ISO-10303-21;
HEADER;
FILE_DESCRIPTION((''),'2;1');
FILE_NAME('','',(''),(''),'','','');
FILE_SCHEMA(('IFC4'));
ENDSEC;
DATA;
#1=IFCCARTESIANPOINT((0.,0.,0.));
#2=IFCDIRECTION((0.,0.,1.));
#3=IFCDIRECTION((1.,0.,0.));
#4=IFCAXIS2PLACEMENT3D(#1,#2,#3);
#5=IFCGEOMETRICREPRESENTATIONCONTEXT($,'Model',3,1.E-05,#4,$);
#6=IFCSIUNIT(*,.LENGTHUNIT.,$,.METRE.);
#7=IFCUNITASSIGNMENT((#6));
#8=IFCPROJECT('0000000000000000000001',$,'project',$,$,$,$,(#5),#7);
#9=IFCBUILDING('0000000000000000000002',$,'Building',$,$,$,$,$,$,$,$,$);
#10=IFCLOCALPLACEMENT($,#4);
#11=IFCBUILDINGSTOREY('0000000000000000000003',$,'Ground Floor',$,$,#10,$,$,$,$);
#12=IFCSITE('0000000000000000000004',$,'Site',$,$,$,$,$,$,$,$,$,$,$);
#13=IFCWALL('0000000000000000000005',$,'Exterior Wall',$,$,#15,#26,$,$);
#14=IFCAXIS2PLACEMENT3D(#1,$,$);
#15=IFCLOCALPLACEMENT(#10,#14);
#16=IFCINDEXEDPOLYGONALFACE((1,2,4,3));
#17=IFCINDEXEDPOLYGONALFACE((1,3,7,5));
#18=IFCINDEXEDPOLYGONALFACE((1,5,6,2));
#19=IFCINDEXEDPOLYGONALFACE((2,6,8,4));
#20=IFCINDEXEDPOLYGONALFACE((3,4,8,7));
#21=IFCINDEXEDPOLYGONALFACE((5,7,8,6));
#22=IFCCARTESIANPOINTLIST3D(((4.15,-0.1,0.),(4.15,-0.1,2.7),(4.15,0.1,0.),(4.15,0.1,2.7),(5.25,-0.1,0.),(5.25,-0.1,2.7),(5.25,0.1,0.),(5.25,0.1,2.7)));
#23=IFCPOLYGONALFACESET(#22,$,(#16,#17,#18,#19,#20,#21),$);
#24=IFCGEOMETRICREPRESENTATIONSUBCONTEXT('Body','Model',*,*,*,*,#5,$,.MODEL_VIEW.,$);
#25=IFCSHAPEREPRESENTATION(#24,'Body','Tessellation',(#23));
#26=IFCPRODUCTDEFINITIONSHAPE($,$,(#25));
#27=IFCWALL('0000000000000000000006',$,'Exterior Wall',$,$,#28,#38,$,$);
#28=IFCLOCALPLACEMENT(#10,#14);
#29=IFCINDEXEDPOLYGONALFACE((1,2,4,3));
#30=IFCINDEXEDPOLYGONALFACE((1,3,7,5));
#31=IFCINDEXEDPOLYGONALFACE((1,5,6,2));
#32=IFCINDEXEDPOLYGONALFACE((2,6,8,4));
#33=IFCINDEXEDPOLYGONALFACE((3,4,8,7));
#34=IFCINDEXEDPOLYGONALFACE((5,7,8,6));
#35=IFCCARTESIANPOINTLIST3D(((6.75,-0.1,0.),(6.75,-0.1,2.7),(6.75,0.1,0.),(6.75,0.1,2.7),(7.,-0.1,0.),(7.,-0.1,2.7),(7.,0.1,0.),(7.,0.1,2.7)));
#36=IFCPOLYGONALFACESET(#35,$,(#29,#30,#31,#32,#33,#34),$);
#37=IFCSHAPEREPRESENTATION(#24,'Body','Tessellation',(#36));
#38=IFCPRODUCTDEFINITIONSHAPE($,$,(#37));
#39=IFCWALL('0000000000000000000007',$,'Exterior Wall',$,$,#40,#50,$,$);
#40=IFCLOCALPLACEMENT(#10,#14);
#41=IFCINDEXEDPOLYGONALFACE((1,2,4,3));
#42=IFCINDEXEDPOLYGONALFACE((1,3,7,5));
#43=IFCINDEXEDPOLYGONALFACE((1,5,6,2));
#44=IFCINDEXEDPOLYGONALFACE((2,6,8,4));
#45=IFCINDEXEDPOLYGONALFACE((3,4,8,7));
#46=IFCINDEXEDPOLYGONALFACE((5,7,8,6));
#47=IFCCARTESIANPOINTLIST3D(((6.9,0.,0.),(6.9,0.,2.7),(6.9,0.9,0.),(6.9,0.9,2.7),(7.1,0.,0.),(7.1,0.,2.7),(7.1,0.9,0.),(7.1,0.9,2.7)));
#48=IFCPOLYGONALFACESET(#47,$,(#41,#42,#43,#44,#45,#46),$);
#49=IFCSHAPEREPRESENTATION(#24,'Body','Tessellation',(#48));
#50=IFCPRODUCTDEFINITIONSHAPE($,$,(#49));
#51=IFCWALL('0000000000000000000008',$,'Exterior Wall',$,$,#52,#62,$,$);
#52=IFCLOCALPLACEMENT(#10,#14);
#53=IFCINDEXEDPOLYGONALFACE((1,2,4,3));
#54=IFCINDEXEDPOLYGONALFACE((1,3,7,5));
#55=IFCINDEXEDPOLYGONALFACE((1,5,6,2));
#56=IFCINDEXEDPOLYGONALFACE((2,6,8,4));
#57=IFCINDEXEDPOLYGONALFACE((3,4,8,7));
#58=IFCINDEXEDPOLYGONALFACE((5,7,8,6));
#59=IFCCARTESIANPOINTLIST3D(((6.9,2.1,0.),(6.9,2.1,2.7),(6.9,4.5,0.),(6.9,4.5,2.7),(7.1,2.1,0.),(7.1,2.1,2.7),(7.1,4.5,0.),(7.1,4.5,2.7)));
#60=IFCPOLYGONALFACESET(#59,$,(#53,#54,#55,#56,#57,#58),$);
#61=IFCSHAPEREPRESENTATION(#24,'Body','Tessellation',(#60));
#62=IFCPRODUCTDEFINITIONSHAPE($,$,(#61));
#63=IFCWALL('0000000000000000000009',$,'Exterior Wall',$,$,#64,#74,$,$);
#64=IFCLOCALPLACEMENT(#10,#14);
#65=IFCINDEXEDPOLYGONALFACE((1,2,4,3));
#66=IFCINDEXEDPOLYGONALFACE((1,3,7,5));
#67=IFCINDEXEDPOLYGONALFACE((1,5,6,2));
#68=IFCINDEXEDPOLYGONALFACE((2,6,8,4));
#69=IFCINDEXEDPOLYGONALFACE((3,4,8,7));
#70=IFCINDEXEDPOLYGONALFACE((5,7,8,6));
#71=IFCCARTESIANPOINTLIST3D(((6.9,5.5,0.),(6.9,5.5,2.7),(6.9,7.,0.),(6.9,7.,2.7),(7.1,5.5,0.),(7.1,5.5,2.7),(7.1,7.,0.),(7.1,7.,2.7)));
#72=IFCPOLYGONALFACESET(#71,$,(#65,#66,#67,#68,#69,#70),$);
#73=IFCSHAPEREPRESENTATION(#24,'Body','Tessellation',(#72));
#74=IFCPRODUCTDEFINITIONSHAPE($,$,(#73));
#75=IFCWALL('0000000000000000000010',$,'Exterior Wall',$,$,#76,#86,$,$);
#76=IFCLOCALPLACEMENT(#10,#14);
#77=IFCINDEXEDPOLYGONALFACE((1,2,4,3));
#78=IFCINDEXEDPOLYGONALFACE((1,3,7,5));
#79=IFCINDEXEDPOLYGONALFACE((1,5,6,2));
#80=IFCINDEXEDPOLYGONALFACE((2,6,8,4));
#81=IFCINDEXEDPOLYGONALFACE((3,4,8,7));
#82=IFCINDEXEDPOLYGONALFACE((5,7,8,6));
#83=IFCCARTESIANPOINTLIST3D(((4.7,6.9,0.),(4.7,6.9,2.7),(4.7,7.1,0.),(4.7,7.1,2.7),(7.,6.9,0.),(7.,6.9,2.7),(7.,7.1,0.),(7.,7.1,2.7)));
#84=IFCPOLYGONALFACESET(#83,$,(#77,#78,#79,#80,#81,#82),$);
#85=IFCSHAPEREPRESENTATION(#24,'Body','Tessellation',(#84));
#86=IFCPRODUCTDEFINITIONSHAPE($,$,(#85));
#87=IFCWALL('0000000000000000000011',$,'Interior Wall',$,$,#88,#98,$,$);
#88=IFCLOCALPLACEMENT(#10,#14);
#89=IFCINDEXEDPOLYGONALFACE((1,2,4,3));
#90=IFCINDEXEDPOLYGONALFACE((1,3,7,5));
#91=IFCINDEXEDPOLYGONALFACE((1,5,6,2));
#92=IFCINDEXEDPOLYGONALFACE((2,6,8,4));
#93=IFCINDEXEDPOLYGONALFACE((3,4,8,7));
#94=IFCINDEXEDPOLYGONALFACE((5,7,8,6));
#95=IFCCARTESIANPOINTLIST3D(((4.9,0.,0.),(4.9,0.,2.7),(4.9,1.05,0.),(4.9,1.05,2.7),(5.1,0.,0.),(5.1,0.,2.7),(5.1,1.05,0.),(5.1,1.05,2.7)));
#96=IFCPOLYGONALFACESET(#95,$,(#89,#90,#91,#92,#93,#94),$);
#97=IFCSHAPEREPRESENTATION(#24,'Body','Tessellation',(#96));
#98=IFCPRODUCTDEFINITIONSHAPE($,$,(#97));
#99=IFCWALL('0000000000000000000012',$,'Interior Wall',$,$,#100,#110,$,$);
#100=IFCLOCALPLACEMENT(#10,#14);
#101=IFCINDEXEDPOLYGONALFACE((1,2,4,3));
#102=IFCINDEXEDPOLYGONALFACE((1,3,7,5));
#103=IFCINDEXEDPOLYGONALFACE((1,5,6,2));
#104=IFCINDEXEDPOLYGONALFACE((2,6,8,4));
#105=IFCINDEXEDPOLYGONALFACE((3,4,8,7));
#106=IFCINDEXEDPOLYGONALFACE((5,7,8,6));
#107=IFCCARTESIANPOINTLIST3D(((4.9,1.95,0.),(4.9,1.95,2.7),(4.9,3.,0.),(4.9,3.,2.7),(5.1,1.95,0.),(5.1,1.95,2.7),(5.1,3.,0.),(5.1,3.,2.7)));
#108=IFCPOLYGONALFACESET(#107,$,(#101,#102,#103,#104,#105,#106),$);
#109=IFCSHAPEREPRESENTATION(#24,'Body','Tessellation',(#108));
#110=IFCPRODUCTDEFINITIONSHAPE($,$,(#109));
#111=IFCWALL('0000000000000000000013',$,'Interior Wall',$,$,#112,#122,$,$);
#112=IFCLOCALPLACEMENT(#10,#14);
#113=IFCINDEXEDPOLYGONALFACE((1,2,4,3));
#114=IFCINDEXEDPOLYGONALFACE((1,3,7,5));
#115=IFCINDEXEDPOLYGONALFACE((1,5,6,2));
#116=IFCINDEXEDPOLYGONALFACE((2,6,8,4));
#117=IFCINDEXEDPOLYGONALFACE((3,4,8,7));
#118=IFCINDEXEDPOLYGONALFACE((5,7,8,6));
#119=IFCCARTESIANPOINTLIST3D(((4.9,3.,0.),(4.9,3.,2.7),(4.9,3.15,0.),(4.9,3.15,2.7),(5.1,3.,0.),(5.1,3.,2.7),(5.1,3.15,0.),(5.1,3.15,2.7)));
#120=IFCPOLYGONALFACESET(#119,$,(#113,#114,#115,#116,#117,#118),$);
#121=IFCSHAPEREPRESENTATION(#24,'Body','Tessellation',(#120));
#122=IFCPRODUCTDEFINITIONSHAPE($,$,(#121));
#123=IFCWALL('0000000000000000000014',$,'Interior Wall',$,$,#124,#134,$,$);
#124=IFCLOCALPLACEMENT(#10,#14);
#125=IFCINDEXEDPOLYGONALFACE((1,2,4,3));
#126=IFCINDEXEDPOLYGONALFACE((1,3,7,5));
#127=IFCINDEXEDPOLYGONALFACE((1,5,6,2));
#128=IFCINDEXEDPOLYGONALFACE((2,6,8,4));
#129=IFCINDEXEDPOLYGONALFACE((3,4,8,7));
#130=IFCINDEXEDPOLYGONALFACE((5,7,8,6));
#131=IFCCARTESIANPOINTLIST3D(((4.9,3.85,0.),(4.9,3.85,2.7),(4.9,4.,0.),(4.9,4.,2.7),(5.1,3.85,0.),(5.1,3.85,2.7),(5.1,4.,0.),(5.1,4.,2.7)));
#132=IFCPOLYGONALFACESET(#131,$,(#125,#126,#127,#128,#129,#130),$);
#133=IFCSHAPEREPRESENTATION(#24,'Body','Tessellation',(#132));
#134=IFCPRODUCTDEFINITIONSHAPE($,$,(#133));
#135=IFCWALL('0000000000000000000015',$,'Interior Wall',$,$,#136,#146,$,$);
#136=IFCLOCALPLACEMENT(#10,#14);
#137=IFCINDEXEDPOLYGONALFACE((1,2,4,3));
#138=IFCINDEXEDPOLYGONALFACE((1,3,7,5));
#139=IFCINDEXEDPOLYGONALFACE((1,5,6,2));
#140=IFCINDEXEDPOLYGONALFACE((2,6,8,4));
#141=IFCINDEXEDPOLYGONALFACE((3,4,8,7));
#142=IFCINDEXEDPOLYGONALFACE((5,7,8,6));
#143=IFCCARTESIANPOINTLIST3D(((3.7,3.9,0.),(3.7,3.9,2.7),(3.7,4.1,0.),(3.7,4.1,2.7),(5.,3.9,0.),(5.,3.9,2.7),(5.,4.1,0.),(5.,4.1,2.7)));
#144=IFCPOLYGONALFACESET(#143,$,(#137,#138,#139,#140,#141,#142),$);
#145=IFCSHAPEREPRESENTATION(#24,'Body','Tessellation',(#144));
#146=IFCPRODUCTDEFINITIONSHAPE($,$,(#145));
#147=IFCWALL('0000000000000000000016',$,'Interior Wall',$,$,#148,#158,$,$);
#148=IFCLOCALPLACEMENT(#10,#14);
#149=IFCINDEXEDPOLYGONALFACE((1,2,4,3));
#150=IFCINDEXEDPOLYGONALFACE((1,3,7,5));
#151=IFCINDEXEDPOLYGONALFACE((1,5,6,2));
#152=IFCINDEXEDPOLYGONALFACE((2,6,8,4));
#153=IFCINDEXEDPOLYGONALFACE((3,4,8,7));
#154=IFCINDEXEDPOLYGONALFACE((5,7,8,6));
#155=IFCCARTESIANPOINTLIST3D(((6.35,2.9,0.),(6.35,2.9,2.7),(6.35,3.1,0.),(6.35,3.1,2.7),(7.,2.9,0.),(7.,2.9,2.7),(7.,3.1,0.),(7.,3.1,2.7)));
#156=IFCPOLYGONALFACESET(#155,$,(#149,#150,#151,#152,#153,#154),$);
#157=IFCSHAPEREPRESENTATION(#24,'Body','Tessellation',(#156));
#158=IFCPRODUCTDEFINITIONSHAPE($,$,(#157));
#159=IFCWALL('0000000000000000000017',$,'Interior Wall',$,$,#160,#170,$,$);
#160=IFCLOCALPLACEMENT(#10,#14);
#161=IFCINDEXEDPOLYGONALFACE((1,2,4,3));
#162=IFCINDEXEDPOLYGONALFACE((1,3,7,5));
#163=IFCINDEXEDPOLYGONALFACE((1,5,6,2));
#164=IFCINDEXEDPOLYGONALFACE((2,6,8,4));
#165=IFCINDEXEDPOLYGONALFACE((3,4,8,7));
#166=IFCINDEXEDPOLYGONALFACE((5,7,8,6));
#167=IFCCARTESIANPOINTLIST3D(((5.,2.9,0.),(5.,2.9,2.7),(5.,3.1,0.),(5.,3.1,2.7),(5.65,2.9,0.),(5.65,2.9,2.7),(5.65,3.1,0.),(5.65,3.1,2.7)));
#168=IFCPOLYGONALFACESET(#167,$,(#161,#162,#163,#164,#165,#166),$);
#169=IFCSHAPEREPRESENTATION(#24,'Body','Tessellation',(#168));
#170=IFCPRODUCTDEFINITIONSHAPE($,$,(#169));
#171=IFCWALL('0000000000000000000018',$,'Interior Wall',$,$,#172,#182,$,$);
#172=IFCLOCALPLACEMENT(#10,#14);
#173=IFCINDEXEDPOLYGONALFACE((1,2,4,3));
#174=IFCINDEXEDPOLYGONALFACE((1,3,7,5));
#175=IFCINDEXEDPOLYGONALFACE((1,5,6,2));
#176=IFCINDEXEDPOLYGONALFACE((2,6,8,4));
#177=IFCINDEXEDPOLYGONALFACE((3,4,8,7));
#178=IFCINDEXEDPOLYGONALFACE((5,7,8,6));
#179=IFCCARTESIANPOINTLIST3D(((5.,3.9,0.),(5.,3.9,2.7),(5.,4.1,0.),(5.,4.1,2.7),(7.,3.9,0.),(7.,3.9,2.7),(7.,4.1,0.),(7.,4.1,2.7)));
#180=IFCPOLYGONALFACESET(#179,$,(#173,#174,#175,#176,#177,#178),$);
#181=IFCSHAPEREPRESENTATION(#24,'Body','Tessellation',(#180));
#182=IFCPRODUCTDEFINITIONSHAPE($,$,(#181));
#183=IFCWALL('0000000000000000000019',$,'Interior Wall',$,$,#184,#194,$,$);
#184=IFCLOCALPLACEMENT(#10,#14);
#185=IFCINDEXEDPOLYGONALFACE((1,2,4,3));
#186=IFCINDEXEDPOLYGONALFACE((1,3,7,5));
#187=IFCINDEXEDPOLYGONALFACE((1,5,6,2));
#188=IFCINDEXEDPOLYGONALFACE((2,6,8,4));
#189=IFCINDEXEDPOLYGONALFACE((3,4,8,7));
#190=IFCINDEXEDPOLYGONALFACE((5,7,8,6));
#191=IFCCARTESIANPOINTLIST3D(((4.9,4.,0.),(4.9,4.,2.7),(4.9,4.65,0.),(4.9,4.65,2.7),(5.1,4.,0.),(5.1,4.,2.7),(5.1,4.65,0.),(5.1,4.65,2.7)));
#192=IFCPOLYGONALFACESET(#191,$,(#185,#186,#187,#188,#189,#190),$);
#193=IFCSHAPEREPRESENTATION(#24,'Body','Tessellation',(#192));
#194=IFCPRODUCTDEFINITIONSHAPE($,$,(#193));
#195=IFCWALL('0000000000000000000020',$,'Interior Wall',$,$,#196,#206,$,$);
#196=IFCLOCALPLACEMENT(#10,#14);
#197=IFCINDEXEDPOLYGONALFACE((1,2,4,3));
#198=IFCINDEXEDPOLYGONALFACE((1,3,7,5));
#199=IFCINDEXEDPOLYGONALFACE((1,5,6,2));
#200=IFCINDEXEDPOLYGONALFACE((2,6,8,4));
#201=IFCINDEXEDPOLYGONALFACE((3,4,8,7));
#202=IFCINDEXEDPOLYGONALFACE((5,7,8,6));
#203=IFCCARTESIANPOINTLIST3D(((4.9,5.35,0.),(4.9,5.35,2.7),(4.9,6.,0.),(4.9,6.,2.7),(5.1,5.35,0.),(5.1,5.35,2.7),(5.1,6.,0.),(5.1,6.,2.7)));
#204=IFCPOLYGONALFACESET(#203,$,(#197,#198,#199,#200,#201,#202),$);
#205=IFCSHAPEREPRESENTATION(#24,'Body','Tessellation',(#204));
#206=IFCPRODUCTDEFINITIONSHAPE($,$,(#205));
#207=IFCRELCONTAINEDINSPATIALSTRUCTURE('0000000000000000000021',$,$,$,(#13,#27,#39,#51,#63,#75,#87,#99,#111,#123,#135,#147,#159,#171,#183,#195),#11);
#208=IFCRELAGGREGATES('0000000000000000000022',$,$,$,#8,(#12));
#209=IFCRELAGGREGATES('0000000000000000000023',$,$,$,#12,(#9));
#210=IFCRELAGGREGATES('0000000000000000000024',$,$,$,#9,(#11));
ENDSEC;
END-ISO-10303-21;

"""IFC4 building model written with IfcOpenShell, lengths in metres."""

from ifc_helpers import new_model, si_unit, frame, origin_with_axes, place, context, subcontext, project, spatial, indexed_curve, outline, extrude, element, save


model = new_model("IFC4")

# Units and contexts
model_context = context("Model", 3, precision=1e-05, world=origin_with_axes())
body_context = subcontext(model_context, "Body", "Model", "MODEL_VIEW")
ifc_project = project(units=[si_unit("LENGTHUNIT", "METRE")], contexts=[model_context])

# Site, building, storey
site = spatial("IfcSite", under=ifc_project, Name="Site")
building = spatial("IfcBuilding", under=site, Name="Building")
storey_placement = place(None, origin_with_axes())
storey = spatial("IfcBuildingStorey", under=building, at=storey_placement, Name="Ground Floor")

# Walls
wall_1_placement = place(storey_placement, frame((4.15, 0.0, 0.0), z_axis=(0.0, 0.0, 1.0), x_axis=(1.0, 0.0, 0.0)))
element("IfcWall", 1, at=wall_1_placement, inside=storey, Name="Exterior Wall", context=body_context, shape_type="SweptSolid", body=[
    extrude(outline(indexed_curve([(0.0, 0.0), (0.0, 0.2), (1.1, 0.2), (1.1, 0.0), (0.0, 0.0)], self_intersect=False)), frame((0.0, -0.1, 0.0), z_axis=(0.0, 0.0, 1.0), x_axis=(1.0, 0.0, 0.0)), (0.0, 0.0, 1.0), 2.7),
])
wall_2_placement = place(storey_placement, frame((6.75, 0.0, 0.0), z_axis=(0.0, 0.0, 1.0), x_axis=(1.0, 0.0, 0.0)))
element("IfcWall", 2, at=wall_2_placement, inside=storey, Name="Exterior Wall", context=body_context, shape_type="SweptSolid", body=[
    extrude(outline(indexed_curve([(0.0, 0.0), (0.0, 0.2), (0.25, 0.2), (0.25, 0.0), (0.0, 0.0)], self_intersect=False)), frame((0.0, -0.1, 0.0), z_axis=(0.0, 0.0, 1.0), x_axis=(1.0, 0.0, 0.0)), (0.0, 0.0, 1.0), 2.7),
])
wall_3_placement = place(storey_placement, frame((7.0, 0.0, 0.0), z_axis=(0.0, 0.0, 1.0), x_axis=(0.0, 1.0, 0.0)))
element("IfcWall", 3, at=wall_3_placement, inside=storey, Name="Exterior Wall", context=body_context, shape_type="SweptSolid", body=[
    extrude(outline(indexed_curve([(0.0, 0.0), (0.0, 0.2), (0.9, 0.2), (0.9, 0.0), (0.0, 0.0)], self_intersect=False)), frame((0.0, -0.1, 0.0), z_axis=(0.0, 0.0, 1.0), x_axis=(1.0, 0.0, 0.0)), (0.0, 0.0, 1.0), 2.7),
])
wall_4_placement = place(storey_placement, frame((7.0, 2.1, 0.0), z_axis=(0.0, 0.0, 1.0), x_axis=(0.0, 1.0, 0.0)))
element("IfcWall", 4, at=wall_4_placement, inside=storey, Name="Exterior Wall", context=body_context, shape_type="SweptSolid", body=[
    extrude(outline(indexed_curve([(0.0, 0.0), (0.0, 0.2), (2.4, 0.2), (2.4, 0.0), (0.0, 0.0)], self_intersect=False)), frame((0.0, -0.1, 0.0), z_axis=(0.0, 0.0, 1.0), x_axis=(1.0, 0.0, 0.0)), (0.0, 0.0, 1.0), 2.7),
])
wall_5_placement = place(storey_placement, frame((7.0, 5.5, 0.0), z_axis=(0.0, 0.0, 1.0), x_axis=(0.0, 1.0, 0.0)))
element("IfcWall", 5, at=wall_5_placement, inside=storey, Name="Exterior Wall", context=body_context, shape_type="SweptSolid", body=[
    extrude(outline(indexed_curve([(0.0, 0.0), (0.0, 0.2), (1.5, 0.2), (1.5, 0.0), (0.0, 0.0)], self_intersect=False)), frame((0.0, -0.1, 0.0), z_axis=(0.0, 0.0, 1.0), x_axis=(1.0, 0.0, 0.0)), (0.0, 0.0, 1.0), 2.7),
])
wall_6_placement = place(storey_placement, frame((7.0, 7.0, 0.0), z_axis=(0.0, 0.0, 1.0), x_axis=(-1.0, 0.0, 0.0)))
element("IfcWall", 6, at=wall_6_placement, inside=storey, Name="Exterior Wall", context=body_context, shape_type="SweptSolid", body=[
    extrude(outline(indexed_curve([(0.0, 0.0), (0.0, 0.2), (2.3, 0.2), (2.3, 0.0), (0.0, 0.0)], self_intersect=False)), frame((0.0, -0.1, 0.0), z_axis=(0.0, 0.0, 1.0), x_axis=(1.0, 0.0, 0.0)), (0.0, 0.0, 1.0), 2.7),
])
for number, where, z_axis, x_axis, name in (
    (7, (5.0, 0.0, 0.0), (0.0, 0.0, 1.0), (0.0, 1.0, 0.0), "Interior Wall"),
    (8, (5.0, 1.95, 0.0), (0.0, 0.0, 1.0), (0.0, 1.0, 0.0), "Interior Wall"),
):
    element("IfcWall", number, at=place(storey_placement, frame(where, z_axis=z_axis, x_axis=x_axis)), inside=storey, Name=name, context=body_context, shape_type="SweptSolid", body=[
        extrude(outline(indexed_curve([(0.0, 0.0), (0.0, 0.2), (1.05, 0.2), (1.05, 0.0), (0.0, 0.0)], self_intersect=False)), frame((0.0, -0.1, 0.0), z_axis=(0.0, 0.0, 1.0), x_axis=(1.0, 0.0, 0.0)), (0.0, 0.0, 1.0), 2.7),
    ])
for number, where, z_axis, x_axis, name in (
    (9, (5.0, 3.0, 0.0), (0.0, 0.0, 1.0), (0.0, 1.0, 0.0), "Interior Wall"),
    (10, (5.0, 3.85, 0.0), (0.0, 0.0, 1.0), (0.0, 1.0, 0.0), "Interior Wall"),
):
    element("IfcWall", number, at=place(storey_placement, frame(where, z_axis=z_axis, x_axis=x_axis)), inside=storey, Name=name, context=body_context, shape_type="SweptSolid", body=[
        extrude(outline(indexed_curve([(0.0, 0.0), (0.0, 0.2), (0.15, 0.2), (0.15, 0.0), (0.0, 0.0)], self_intersect=False)), frame((0.0, -0.1, 0.0), z_axis=(0.0, 0.0, 1.0), x_axis=(1.0, 0.0, 0.0)), (0.0, 0.0, 1.0), 2.7),
    ])
wall_7_placement = place(storey_placement, frame((5.0, 4.0, 0.0), z_axis=(0.0, 0.0, 1.0), x_axis=(-1.0, 0.0, 0.0)))
element("IfcWall", 11, at=wall_7_placement, inside=storey, Name="Interior Wall", context=body_context, shape_type="SweptSolid", body=[
    extrude(outline(indexed_curve([(0.0, 0.0), (0.0, 0.2), (1.3, 0.2), (1.3, 0.0), (0.0, 0.0)], self_intersect=False)), frame((0.0, -0.1, 0.0), z_axis=(0.0, 0.0, 1.0), x_axis=(1.0, 0.0, 0.0)), (0.0, 0.0, 1.0), 2.7),
])
for number, where, z_axis, x_axis, name in (
    (12, (7.0, 3.0, 0.0), (0.0, 0.0, 1.0), (-1.0, 0.0, 0.0), "Interior Wall"),
    (13, (5.65, 3.0, 0.0), (0.0, 0.0, 1.0), (-1.0, 0.0, 0.0), "Interior Wall"),
):
    element("IfcWall", number, at=place(storey_placement, frame(where, z_axis=z_axis, x_axis=x_axis)), inside=storey, Name=name, context=body_context, shape_type="SweptSolid", body=[
        extrude(outline(indexed_curve([(0.0, 0.0), (0.0, 0.2), (0.65, 0.2), (0.65, 0.0), (0.0, 0.0)], self_intersect=False)), frame((0.0, -0.1, 0.0), z_axis=(0.0, 0.0, 1.0), x_axis=(1.0, 0.0, 0.0)), (0.0, 0.0, 1.0), 2.7),
    ])
wall_8_placement = place(storey_placement, frame((7.0, 4.0, 0.0), z_axis=(0.0, 0.0, 1.0), x_axis=(-1.0, 0.0, 0.0)))
element("IfcWall", 14, at=wall_8_placement, inside=storey, Name="Interior Wall", context=body_context, shape_type="SweptSolid", body=[
    extrude(outline(indexed_curve([(0.0, 0.0), (0.0, 0.2), (2.0, 0.2), (2.0, 0.0), (0.0, 0.0)], self_intersect=False)), frame((0.0, -0.1, 0.0), z_axis=(0.0, 0.0, 1.0), x_axis=(1.0, 0.0, 0.0)), (0.0, 0.0, 1.0), 2.7),
])
for number, where, z_axis, x_axis, name in (
    (15, (5.0, 4.0, 0.0), (0.0, 0.0, 1.0), (0.0, 1.0, 0.0), "Interior Wall"),
    (16, (5.0, 5.35, 0.0), (0.0, 0.0, 1.0), (0.0, 1.0, 0.0), "Interior Wall"),
):
    element("IfcWall", number, at=place(storey_placement, frame(where, z_axis=z_axis, x_axis=x_axis)), inside=storey, Name=name, context=body_context, shape_type="SweptSolid", body=[
        extrude(outline(indexed_curve([(0.0, 0.0), (0.0, 0.2), (0.65, 0.2), (0.65, 0.0), (0.0, 0.0)], self_intersect=False)), frame((0.0, -0.1, 0.0), z_axis=(0.0, 0.0, 1.0), x_axis=(1.0, 0.0, 0.0)), (0.0, 0.0, 1.0), 2.7),
    ])

save(model, "model.ifc")
